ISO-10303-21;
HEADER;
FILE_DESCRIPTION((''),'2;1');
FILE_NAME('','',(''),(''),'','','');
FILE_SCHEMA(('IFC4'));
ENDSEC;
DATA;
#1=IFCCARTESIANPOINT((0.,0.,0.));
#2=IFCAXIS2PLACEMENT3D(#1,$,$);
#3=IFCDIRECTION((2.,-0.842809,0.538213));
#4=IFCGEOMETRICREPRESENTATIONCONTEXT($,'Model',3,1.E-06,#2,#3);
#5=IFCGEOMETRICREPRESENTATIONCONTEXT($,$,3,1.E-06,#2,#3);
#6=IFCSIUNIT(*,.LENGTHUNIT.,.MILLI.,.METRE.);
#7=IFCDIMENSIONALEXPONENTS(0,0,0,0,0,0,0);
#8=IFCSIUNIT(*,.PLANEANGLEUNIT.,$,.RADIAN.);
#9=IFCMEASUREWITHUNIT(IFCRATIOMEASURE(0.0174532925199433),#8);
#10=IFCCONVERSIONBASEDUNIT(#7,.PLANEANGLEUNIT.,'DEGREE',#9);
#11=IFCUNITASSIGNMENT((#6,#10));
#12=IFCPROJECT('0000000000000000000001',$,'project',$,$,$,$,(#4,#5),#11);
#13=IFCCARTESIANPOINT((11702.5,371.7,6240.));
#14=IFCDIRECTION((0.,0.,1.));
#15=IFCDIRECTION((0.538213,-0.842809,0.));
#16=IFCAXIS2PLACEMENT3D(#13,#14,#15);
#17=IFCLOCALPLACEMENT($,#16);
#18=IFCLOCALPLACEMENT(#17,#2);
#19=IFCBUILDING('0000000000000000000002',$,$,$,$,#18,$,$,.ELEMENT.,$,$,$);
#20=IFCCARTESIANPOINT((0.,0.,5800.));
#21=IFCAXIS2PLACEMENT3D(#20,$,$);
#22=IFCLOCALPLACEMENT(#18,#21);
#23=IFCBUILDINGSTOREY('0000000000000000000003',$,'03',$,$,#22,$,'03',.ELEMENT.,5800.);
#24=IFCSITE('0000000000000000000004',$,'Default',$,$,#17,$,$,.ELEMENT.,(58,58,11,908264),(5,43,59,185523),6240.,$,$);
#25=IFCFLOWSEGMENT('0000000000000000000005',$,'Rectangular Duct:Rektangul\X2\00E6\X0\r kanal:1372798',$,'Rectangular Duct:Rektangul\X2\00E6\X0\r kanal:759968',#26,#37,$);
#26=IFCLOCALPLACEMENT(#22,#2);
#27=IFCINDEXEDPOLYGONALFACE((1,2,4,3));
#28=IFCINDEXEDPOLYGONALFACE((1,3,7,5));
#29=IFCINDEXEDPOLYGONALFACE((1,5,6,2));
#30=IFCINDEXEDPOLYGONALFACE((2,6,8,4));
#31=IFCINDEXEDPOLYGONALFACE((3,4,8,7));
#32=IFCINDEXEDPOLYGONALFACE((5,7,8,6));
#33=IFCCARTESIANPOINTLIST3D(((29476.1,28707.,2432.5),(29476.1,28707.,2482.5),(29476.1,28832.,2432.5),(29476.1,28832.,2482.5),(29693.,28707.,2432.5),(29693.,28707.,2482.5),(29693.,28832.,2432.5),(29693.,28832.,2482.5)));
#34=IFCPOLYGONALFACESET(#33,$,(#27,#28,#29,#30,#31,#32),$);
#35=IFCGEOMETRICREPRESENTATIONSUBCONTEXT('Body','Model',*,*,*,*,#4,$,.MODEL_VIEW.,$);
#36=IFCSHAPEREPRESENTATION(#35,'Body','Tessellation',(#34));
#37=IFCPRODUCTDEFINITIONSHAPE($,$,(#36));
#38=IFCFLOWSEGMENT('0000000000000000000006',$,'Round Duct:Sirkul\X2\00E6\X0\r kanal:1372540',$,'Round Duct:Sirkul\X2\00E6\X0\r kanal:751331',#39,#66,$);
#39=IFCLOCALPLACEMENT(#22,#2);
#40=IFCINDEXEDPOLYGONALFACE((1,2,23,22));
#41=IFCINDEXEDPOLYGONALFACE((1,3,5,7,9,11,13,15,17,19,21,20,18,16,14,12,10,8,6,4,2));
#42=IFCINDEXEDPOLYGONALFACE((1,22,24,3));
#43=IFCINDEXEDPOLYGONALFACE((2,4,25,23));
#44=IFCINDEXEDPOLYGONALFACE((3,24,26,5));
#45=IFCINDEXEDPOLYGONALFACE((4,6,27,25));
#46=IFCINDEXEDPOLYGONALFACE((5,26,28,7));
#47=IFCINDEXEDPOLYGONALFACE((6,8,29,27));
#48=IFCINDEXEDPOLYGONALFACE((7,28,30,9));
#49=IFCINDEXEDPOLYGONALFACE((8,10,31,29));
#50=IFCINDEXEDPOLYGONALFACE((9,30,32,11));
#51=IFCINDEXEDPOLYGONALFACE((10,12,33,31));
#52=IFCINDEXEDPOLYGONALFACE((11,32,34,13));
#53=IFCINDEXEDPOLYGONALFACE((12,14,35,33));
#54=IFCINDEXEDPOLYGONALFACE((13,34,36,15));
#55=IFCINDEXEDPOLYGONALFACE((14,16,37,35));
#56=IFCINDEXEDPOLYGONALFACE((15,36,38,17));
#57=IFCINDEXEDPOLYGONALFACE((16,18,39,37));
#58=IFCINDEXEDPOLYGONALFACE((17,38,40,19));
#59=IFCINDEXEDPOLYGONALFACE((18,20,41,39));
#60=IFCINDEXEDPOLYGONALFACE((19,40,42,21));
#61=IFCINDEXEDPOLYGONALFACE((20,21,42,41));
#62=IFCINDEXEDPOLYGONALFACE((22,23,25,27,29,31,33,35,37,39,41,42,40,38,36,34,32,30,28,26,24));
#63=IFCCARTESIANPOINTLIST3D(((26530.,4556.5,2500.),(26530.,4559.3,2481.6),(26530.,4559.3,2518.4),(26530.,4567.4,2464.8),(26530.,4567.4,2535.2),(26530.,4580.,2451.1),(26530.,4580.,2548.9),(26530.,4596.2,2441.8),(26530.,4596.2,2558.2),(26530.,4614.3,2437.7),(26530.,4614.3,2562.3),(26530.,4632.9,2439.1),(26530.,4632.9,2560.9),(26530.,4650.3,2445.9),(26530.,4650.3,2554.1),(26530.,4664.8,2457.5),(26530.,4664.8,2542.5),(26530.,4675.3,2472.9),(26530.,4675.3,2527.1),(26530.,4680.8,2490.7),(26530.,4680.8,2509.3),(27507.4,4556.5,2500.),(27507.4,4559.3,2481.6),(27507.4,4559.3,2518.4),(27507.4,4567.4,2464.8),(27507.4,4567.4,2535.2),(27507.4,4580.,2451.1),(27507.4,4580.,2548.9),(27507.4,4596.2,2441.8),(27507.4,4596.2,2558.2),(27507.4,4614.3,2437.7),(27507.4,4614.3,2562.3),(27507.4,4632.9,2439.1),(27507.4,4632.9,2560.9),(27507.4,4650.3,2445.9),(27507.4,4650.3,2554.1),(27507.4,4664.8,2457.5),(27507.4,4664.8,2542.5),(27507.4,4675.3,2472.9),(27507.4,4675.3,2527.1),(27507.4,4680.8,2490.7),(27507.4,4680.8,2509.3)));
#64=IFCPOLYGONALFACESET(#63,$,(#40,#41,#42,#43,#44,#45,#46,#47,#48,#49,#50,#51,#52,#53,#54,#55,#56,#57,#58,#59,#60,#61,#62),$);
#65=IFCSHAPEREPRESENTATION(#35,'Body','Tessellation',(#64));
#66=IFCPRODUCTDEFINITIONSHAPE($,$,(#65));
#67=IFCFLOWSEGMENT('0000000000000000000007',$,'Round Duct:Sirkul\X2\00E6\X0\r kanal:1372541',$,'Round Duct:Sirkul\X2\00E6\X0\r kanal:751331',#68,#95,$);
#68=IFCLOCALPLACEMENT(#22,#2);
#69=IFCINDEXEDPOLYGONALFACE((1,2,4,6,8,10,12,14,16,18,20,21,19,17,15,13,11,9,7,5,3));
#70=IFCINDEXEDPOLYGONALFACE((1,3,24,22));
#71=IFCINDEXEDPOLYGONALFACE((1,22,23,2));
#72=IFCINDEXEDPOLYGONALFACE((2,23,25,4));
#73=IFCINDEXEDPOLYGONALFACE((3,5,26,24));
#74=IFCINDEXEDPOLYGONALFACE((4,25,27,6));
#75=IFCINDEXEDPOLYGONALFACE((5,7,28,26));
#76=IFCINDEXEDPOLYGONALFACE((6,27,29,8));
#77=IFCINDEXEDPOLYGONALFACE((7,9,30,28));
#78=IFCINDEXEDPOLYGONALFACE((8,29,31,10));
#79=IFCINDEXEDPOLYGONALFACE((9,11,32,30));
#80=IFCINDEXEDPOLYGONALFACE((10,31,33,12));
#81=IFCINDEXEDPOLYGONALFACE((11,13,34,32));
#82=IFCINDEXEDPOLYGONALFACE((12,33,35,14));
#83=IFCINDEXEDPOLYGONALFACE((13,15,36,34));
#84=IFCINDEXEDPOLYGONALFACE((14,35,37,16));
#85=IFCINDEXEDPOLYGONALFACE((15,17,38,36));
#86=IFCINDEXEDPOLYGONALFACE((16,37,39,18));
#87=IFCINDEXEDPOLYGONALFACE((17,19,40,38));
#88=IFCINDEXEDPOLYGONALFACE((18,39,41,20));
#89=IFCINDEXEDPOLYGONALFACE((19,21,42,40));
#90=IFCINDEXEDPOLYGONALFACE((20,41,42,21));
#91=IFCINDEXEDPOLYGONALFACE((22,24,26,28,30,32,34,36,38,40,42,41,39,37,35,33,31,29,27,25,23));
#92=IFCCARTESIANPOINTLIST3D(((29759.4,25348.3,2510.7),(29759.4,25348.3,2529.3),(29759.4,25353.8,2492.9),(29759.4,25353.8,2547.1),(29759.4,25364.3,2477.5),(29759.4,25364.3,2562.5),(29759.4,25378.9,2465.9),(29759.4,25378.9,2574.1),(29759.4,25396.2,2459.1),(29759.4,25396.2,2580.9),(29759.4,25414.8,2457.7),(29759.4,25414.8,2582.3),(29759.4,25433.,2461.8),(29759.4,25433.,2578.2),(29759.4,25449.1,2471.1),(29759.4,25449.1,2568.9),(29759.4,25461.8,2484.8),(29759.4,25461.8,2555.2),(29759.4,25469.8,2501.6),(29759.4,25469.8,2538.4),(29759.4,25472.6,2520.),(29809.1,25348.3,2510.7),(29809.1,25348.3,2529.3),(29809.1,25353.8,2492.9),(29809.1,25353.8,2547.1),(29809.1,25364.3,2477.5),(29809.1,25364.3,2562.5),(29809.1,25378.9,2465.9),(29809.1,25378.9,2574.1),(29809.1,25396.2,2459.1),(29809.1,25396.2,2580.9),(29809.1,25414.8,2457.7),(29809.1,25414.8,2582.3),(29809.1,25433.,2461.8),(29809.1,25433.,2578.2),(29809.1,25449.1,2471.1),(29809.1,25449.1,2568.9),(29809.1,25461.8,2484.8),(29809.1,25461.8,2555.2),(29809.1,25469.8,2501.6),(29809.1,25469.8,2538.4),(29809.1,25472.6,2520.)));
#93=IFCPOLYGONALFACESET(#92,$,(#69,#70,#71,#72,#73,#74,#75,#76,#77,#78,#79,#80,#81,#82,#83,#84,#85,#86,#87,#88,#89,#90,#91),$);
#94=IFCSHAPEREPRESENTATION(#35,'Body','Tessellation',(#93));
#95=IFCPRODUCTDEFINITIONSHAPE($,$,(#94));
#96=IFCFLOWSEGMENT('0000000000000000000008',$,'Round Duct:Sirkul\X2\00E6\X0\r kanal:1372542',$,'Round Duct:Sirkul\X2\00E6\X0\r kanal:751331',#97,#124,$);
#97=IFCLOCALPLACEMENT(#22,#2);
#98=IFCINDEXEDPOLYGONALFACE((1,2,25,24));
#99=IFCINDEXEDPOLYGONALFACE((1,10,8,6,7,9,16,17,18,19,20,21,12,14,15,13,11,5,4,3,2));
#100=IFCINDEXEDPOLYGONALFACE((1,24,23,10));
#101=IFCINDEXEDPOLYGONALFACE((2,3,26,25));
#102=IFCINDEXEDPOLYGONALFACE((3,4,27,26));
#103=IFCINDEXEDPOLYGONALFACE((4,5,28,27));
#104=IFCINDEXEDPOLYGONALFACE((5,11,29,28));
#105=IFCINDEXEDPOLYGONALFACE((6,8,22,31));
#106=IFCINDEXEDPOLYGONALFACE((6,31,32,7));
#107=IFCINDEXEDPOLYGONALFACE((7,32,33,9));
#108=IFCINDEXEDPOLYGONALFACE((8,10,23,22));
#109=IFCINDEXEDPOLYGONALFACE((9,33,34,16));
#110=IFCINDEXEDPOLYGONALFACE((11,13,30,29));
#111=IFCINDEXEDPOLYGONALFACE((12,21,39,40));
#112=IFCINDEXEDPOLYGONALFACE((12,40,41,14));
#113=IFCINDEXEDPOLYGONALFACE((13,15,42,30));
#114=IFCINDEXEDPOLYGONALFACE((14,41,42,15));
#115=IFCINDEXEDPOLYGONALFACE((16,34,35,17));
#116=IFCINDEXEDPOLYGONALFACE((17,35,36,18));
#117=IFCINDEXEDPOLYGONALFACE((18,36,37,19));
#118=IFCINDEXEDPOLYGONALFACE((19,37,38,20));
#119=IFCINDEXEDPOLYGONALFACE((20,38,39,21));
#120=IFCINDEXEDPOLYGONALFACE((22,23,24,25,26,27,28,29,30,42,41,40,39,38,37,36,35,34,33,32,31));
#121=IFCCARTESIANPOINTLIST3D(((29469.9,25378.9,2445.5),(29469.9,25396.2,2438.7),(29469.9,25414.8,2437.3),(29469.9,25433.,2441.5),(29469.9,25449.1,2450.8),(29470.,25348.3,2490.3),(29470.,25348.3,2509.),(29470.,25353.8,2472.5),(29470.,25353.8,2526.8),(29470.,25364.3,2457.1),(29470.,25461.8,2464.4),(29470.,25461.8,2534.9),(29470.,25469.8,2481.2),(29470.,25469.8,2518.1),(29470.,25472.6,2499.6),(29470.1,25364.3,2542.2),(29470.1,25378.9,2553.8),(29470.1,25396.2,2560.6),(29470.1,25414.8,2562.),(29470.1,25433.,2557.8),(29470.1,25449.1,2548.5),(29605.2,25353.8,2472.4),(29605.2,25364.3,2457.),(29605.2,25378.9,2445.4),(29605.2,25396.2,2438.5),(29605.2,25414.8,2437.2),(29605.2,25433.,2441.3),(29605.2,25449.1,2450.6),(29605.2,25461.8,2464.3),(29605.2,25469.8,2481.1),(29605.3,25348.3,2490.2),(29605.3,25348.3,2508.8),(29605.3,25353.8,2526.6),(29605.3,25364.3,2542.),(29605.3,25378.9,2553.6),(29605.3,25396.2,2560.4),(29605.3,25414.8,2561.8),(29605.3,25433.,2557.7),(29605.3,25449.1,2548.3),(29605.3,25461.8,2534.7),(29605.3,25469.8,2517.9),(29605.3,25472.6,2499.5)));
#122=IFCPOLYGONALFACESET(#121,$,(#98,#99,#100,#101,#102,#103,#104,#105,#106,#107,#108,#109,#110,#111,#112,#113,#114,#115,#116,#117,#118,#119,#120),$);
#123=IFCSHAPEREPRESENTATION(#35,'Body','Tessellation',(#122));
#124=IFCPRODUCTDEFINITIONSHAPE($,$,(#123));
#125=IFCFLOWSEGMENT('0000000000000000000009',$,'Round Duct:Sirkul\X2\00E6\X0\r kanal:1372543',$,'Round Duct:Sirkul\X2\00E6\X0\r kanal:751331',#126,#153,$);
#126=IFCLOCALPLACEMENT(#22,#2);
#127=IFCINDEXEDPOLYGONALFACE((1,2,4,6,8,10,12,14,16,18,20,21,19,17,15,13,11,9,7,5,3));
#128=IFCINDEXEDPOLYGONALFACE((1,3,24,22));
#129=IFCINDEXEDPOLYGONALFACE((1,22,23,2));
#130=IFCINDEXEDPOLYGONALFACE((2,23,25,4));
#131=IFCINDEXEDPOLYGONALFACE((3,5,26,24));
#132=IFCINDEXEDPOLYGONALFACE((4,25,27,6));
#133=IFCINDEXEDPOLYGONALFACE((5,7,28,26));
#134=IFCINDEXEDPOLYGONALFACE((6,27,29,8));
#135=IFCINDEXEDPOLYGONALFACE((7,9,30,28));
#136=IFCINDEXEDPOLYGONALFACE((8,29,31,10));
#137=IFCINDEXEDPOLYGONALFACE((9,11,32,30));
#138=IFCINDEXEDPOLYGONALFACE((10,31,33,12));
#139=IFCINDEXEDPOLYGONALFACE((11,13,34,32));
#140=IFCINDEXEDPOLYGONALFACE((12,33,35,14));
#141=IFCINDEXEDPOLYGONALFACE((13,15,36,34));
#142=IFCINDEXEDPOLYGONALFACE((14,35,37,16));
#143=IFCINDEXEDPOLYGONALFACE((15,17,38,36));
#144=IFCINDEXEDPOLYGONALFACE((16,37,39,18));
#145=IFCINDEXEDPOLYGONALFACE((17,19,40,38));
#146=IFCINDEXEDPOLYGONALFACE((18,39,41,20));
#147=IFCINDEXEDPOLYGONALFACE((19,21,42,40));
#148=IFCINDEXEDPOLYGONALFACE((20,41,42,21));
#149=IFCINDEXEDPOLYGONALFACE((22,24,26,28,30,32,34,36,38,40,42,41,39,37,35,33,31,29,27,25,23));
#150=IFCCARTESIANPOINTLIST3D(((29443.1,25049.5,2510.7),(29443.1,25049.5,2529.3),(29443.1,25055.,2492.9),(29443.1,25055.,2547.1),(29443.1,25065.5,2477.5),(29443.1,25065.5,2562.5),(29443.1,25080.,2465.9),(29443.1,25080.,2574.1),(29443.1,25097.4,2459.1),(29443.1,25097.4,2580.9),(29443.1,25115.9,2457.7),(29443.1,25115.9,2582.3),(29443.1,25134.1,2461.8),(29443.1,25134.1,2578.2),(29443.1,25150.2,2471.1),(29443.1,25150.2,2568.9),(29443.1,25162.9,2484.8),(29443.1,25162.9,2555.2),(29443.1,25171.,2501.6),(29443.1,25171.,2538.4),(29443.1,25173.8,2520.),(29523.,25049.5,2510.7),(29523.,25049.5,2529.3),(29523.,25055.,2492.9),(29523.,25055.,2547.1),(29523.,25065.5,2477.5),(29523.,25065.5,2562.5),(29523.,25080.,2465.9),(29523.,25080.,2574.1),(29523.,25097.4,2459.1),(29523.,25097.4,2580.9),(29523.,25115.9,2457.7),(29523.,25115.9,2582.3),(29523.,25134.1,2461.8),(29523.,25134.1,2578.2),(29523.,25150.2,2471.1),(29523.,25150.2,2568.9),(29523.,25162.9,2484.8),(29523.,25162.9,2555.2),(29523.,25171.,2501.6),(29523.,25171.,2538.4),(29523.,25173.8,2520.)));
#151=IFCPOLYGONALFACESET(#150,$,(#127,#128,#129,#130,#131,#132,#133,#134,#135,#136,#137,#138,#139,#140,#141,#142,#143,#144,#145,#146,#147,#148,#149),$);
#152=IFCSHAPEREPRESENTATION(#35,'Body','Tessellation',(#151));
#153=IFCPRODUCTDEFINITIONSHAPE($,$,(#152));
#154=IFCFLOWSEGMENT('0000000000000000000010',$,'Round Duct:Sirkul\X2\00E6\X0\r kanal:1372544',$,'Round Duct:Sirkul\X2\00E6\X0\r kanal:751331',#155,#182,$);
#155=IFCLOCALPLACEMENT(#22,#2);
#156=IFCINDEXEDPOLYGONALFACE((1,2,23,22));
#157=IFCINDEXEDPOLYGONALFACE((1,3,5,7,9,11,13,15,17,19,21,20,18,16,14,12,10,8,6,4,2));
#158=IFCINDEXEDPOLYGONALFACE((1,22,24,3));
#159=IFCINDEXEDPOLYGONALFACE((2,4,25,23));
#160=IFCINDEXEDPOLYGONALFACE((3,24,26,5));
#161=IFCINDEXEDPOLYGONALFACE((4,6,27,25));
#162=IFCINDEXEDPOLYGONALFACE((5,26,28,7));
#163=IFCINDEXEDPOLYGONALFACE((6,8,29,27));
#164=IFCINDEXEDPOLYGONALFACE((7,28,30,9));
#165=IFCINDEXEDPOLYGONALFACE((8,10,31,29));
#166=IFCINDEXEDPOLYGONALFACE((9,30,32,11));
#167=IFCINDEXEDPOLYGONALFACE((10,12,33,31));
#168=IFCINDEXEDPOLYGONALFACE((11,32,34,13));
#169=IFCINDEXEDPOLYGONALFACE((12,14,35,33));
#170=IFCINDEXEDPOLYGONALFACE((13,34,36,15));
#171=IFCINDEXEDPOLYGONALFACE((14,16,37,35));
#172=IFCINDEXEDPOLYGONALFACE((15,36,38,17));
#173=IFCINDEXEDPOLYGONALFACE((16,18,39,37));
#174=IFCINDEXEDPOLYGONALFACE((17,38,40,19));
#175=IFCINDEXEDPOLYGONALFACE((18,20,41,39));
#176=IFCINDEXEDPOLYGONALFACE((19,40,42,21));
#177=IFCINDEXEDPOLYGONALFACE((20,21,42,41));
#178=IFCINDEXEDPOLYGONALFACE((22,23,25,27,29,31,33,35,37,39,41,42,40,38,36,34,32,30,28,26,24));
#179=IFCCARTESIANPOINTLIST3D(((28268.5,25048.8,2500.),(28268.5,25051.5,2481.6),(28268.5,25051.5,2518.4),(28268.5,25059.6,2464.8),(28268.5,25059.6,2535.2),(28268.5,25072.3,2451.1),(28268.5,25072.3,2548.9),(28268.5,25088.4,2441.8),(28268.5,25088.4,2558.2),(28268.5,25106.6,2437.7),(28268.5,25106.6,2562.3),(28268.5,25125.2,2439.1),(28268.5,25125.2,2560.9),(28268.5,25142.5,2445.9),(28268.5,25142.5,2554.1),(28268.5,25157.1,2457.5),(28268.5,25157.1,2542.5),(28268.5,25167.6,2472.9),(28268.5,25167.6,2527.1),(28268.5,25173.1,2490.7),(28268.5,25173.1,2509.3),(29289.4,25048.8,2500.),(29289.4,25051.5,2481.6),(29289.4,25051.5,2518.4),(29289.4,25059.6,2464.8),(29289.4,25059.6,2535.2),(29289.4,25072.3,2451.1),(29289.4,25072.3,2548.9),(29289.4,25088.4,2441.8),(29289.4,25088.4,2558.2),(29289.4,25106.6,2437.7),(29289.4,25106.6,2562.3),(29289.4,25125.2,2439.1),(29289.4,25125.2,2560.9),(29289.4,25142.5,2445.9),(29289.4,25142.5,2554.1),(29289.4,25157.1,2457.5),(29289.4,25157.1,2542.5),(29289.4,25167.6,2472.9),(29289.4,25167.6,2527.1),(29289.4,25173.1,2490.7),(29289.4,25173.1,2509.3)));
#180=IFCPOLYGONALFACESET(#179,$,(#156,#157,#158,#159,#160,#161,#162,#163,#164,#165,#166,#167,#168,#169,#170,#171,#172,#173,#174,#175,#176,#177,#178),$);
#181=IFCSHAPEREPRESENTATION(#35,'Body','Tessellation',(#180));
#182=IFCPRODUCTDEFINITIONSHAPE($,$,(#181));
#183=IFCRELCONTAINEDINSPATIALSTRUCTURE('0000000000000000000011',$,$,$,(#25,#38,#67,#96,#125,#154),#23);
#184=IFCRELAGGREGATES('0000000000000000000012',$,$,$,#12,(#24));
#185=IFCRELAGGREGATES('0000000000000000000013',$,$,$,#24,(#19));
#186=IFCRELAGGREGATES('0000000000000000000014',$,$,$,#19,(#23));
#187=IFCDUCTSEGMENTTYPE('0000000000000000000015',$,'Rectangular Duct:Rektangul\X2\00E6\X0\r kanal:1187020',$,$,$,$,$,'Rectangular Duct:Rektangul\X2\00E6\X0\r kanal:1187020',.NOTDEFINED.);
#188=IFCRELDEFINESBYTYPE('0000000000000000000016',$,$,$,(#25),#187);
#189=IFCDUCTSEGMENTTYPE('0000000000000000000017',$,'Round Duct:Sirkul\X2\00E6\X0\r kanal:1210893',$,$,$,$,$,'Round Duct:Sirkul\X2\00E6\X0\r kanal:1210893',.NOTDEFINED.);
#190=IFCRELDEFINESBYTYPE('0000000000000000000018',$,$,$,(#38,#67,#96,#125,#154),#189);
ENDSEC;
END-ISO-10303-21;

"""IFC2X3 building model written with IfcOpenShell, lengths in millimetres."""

from ifc_helpers import new_model, entity, si_unit, converted_unit, direction, frame, frame_2d, origin, origin_2d_with_axis, place, context, subcontext, project, spatial, rectangle, circle, extrude, type_object, element, save


model = new_model("IFC2X3")

# Units and contexts
model_context = context("Model", 3, precision=1e-06, world=origin(), true_north=direction((2.0, -0.842809, 0.538213)))
context_of_model = context(None, 3, precision=1e-06, world=origin(), true_north=direction((2.0, -0.842809, 0.538213)))
body_context = subcontext(model_context, "Body", "Model", "MODEL_VIEW")
ifc_project = project(units=[si_unit("LENGTHUNIT", "METRE", prefix="MILLI"), converted_unit("PLANEANGLEUNIT", "DEGREE", entity("IfcRatioMeasure", 0.0174532925199433), si_unit("PLANEANGLEUNIT", "RADIAN"), dimensions=[0, 0, 0, 0, 0, 0, 0])], contexts=[model_context, context_of_model])

# Site, building, storey
site_placement = place(None, frame((11702.5, 371.7, 6240.0), z_axis=(0.0, 0.0, 1.0), x_axis=(0.538213, -0.842809, 0.0)))
site = spatial("IfcSite", under=ifc_project, at=site_placement, Name="Default", CompositionType="ELEMENT", RefLatitude=(58, 58, 11, 908264), RefLongitude=(5, 43, 59, 185523), RefElevation=6240.0)
building_placement = place(site_placement, origin())
building = spatial("IfcBuilding", under=site, at=building_placement, CompositionType="ELEMENT")
storey_placement = place(building_placement, frame((0.0, 0.0, 5800.0)))
storey = spatial("IfcBuildingStorey", under=building, at=storey_placement, Name="03", LongName="03", CompositionType="ELEMENT", Elevation=5800.0)

# Flow segments
duct_segment_type_1 = type_object("IfcDuctSegmentType", Name="Rectangular Duct:Rektangulær kanal:1187020", ElementType="Rectangular Duct:Rektangulær kanal:1187020", PredefinedType="NOTDEFINED")
flow_segment_1_placement = place(storey_placement, origin())
element("IfcFlowSegment", 1, at=flow_segment_1_placement, inside=storey, type_object=duct_segment_type_1, Name="Rectangular Duct:Rektangulær kanal:1372798", ObjectType="Rectangular Duct:Rektangulær kanal:759968", context=body_context, shape_type="SweptSolid", body=[
    extrude(rectangle(XDim=216.9, YDim=125.0, at=frame_2d((0.0, 0.0), x_axis=(1.0, 0.0))), frame((29584.6, 28769.5, 2432.5), z_axis=(0.0, 0.0, 1.0), x_axis=(-1.0, 0.0, 0.0)), (0.0, 0.0, 1.0), 50.0),
])
duct_segment_type_2 = type_object("IfcDuctSegmentType", Name="Round Duct:Sirkulær kanal:1210893", ElementType="Round Duct:Sirkulær kanal:1210893", PredefinedType="NOTDEFINED")
flow_segment_2_placement = place(storey_placement, origin())
element("IfcFlowSegment", 2, at=flow_segment_2_placement, inside=storey, type_object=duct_segment_type_2, Name="Round Duct:Sirkulær kanal:1372540", ObjectType="Round Duct:Sirkulær kanal:751331", context=body_context, shape_type="SweptSolid", body=[
    extrude(circle(Radius=62.5, at=frame_2d((0.0, 0.0), x_axis=(1.0, 0.0))), frame((26530.0, 4619.0, 2500.0), z_axis=(1.0, 0.0, 0.0), x_axis=(0.0, -1.0, 0.0)), (0.0, 0.0, 1.0), 977.4),
])
flow_segment_3_placement = place(storey_placement, origin())
element("IfcFlowSegment", 3, at=flow_segment_3_placement, inside=storey, type_object=duct_segment_type_2, Name="Round Duct:Sirkulær kanal:1372541", ObjectType="Round Duct:Sirkulær kanal:751331", context=body_context, shape_type="SweptSolid", body=[
    extrude(circle(Radius=62.5, at=frame_2d((0.0, 0.0), x_axis=(1.0, 0.0))), frame((29759.4, 25410.1, 2520.0), z_axis=(1.0, 0.0, 0.0), x_axis=(0.0, 1.0, 0.0)), (0.0, 0.0, 1.0), 49.6),
])
flow_segment_4_placement = place(storey_placement, origin())
element("IfcFlowSegment", 4, at=flow_segment_4_placement, inside=storey, type_object=duct_segment_type_2, Name="Round Duct:Sirkulær kanal:1372542", ObjectType="Round Duct:Sirkulær kanal:751331", context=body_context, shape_type="SweptSolid", body=[
    extrude(circle(Radius=62.5, at=origin_2d_with_axis()), frame((29470.0, 25410.1, 2499.6), z_axis=(0.999999, 0.0, -0.001244), x_axis=(0.0, 1.0, 0.0)), (0.0, 0.0, 1.0), 135.3),
])
flow_segment_5_placement = place(storey_placement, origin())
element("IfcFlowSegment", 5, at=flow_segment_5_placement, inside=storey, type_object=duct_segment_type_2, Name="Round Duct:Sirkulær kanal:1372543", ObjectType="Round Duct:Sirkulær kanal:751331", context=body_context, shape_type="SweptSolid", body=[
    extrude(circle(Radius=62.5, at=frame_2d((0.0, 0.0), x_axis=(1.0, 0.0))), frame((29443.1, 25111.3, 2520.0), z_axis=(1.0, 0.0, 0.0), x_axis=(0.0, 1.0, 0.0)), (0.0, 0.0, 1.0), 79.9),
])
flow_segment_6_placement = place(storey_placement, origin())
element("IfcFlowSegment", 6, at=flow_segment_6_placement, inside=storey, type_object=duct_segment_type_2, Name="Round Duct:Sirkulær kanal:1372544", ObjectType="Round Duct:Sirkulær kanal:751331", context=body_context, shape_type="SweptSolid", body=[
    extrude(circle(Radius=62.5, at=frame_2d((0.0, 0.0), x_axis=(1.0, 0.0))), frame((28268.5, 25111.3, 2500.0), z_axis=(1.0, 0.0, 0.0), x_axis=(0.0, -1.0, 0.0)), (0.0, 0.0, 1.0), 1020.9),
])

save(model, "model.ifc")
